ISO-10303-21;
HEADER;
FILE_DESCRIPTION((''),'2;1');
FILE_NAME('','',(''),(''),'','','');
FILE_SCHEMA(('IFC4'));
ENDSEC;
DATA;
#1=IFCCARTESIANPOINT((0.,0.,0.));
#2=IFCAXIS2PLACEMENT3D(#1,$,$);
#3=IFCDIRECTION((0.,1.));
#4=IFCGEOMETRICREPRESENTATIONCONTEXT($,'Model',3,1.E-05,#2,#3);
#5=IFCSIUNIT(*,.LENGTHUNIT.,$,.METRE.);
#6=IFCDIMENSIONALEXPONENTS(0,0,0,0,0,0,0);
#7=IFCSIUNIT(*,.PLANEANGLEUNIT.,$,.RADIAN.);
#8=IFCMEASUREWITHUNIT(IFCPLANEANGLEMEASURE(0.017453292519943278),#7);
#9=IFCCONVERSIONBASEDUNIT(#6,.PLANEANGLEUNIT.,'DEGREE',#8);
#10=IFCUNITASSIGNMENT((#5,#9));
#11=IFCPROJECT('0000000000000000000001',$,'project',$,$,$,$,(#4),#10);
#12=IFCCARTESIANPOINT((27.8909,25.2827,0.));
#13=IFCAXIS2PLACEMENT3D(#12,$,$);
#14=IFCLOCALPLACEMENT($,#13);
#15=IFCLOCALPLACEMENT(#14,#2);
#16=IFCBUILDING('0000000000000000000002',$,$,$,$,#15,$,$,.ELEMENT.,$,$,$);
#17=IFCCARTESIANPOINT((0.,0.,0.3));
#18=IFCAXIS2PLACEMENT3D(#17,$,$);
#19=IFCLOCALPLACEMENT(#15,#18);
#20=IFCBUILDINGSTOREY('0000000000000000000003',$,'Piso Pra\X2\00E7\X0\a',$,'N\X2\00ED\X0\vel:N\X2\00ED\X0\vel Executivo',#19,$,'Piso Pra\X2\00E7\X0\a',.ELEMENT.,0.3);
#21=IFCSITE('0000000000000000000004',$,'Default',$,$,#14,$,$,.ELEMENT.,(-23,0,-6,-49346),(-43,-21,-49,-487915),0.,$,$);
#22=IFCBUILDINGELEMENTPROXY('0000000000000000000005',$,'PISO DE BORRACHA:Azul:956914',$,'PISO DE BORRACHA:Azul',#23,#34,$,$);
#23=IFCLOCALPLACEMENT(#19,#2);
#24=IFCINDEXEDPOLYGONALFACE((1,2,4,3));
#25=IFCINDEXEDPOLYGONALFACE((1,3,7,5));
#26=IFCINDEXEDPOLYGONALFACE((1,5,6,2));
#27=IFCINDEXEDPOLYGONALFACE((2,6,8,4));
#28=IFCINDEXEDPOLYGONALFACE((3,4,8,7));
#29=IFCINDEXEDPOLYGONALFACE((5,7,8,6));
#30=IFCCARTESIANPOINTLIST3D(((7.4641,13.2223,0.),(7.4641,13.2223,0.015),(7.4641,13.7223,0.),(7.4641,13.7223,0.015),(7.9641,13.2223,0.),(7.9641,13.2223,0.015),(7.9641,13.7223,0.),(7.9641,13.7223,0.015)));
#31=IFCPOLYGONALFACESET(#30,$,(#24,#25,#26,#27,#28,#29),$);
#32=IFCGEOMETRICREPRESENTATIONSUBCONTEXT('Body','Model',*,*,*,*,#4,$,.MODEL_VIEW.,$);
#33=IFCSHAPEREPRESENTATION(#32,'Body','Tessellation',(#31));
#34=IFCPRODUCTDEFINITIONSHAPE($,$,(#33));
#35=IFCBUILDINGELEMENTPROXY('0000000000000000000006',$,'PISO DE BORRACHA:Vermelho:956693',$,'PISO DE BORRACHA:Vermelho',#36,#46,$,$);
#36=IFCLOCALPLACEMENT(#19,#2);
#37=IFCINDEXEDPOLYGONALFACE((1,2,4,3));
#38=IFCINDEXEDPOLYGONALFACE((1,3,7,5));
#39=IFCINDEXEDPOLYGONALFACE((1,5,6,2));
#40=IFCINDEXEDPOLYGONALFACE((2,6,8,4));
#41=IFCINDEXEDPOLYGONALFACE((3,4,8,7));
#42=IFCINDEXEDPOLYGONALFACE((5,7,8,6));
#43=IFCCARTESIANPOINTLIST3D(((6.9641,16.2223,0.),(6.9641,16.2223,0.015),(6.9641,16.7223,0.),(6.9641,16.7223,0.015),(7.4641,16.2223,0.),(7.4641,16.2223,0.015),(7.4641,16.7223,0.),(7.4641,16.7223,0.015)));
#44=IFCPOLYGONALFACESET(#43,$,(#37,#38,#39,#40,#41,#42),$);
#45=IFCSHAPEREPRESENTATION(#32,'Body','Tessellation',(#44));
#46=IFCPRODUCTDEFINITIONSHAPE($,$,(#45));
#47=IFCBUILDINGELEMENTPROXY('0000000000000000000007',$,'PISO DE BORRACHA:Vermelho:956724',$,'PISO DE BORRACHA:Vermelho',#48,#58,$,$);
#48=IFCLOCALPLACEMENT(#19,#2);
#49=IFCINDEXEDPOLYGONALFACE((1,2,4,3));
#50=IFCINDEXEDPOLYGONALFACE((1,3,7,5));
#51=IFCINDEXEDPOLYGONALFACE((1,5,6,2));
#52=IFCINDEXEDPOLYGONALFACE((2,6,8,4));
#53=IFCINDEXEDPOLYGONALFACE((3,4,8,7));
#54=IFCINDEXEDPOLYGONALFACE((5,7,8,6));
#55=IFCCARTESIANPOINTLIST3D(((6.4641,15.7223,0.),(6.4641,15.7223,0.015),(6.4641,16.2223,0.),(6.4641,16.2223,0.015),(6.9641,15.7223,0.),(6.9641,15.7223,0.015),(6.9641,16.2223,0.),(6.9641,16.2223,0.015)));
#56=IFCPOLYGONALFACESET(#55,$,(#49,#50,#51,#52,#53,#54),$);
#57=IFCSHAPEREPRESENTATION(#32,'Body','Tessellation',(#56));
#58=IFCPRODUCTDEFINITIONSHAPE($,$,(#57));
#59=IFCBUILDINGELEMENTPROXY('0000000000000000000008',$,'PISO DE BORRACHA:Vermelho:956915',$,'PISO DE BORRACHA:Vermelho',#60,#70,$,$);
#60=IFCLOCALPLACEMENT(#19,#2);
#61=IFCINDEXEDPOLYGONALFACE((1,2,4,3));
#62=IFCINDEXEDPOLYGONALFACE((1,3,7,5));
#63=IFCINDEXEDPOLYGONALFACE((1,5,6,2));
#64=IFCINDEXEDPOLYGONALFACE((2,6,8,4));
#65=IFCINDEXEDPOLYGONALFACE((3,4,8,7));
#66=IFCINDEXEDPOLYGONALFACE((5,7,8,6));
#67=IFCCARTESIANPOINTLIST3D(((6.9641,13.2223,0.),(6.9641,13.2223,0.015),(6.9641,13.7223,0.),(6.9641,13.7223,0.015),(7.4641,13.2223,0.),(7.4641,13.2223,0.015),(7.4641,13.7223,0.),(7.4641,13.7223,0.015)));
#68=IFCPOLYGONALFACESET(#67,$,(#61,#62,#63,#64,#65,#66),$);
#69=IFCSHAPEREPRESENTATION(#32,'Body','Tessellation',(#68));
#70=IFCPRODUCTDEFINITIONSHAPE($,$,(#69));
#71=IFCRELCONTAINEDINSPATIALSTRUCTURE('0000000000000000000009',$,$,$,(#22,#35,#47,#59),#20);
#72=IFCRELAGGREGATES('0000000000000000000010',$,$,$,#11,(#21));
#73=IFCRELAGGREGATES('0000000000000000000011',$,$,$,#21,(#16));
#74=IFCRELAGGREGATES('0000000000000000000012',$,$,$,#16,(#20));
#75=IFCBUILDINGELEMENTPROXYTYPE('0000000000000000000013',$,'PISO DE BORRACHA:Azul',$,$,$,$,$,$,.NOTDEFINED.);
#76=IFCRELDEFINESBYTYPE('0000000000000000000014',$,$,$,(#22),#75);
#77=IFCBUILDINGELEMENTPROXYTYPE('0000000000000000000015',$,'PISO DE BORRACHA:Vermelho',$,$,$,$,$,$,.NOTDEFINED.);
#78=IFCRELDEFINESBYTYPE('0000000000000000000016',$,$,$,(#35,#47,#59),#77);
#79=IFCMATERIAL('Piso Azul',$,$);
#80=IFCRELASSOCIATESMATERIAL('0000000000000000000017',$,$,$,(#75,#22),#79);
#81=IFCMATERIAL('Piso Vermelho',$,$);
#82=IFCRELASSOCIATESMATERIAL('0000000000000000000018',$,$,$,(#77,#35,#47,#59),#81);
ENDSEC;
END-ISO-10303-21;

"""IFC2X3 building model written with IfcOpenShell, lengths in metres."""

from ifc_helpers import new_model, entity, si_unit, converted_unit, direction, frame, origin, origin_2d_with_axis, place, context, subcontext, project, spatial, rectangle, extrude, source, transform, mapped, material, type_object, type_shapes, element, save


model = new_model("IFC2X3")

# Units and contexts
model_context = context("Model", 3, precision=1e-05, world=origin(), true_north=direction((0.0, 1.0)))
body_context = subcontext(model_context, "Body", "Model", "MODEL_VIEW")
ifc_project = project(units=[si_unit("LENGTHUNIT", "METRE"), converted_unit("PLANEANGLEUNIT", "DEGREE", entity("IfcPlaneAngleMeasure", 0.017453292519943278), si_unit("PLANEANGLEUNIT", "RADIAN"), dimensions=[0, 0, 0, 0, 0, 0, 0])], contexts=[model_context])

# Site, building, storey
site_placement = place(None, frame((27.8909, 25.2827, 0.0)))
site = spatial("IfcSite", under=ifc_project, at=site_placement, Name="Default", CompositionType="ELEMENT", RefLatitude=(-23, 0, -6, -49346), RefLongitude=(-43, -21, -49, -487915), RefElevation=0.0)
building_placement = place(site_placement, origin())
building = spatial("IfcBuilding", under=site, at=building_placement, CompositionType="ELEMENT")
storey_placement = place(building_placement, frame((0.0, 0.0, 0.3)))
storey = spatial("IfcBuildingStorey", under=building, at=storey_placement, Name="Piso Praça", ObjectType="Nível:Nível Executivo", LongName="Piso Praça", CompositionType="ELEMENT", Elevation=0.3)

# Building element proxies
ifc_material_1 = material(Name="Piso Azul")
building_element_proxy_type_1 = type_object("IfcBuildingElementProxyType", Name="PISO DE BORRACHA:Azul", PredefinedType="NOTDEFINED", material=ifc_material_1)
shared_shape_1 = source(origin(), body_context, "Body", "SweptSolid", [
    extrude(rectangle(XDim=0.5, YDim=0.5, at=origin_2d_with_axis()), frame((0.25, 0.25, 0.0), z_axis=(0.0, 0.0, 1.0), x_axis=(-1.0, 0.0, 0.0)), (0.0, 0.0, 1.0), 0.015),
])
type_shapes(building_element_proxy_type_1, [shared_shape_1])
for number, where, name in (
    (1, (7.4641, 13.2223, 0.0), "PISO DE BORRACHA:Azul:956914"),
):
    element("IfcBuildingElementProxy", number, at=place(storey_placement, frame(where)), inside=storey, type_object=building_element_proxy_type_1, material=ifc_material_1, Name=name, ObjectType="PISO DE BORRACHA:Azul", context=body_context, shape_type="MappedRepresentation", body=[
        mapped(shared_shape_1, transform((0.0, 0.0, 0.0), scale=1.0)),
    ])
ifc_material_2 = material(Name="Piso Vermelho")
building_element_proxy_type_2 = type_object("IfcBuildingElementProxyType", Name="PISO DE BORRACHA:Vermelho", PredefinedType="NOTDEFINED", material=ifc_material_2)
shared_shape_2 = source(origin(), body_context, "Body", "SweptSolid", [
    extrude(rectangle(XDim=0.5, YDim=0.5, at=origin_2d_with_axis()), frame((0.25, 0.25, 0.0), z_axis=(0.0, 0.0, 1.0), x_axis=(-1.0, 0.0, 0.0)), (0.0, 0.0, 1.0), 0.015),
])
type_shapes(building_element_proxy_type_2, [shared_shape_2])
for number, where, name in (
    (2, (6.9641, 16.2223, 0.0), "PISO DE BORRACHA:Vermelho:956693"),
    (3, (6.4641, 15.7223, 0.0), "PISO DE BORRACHA:Vermelho:956724"),
    (4, (6.9641, 13.2223, 0.0), "PISO DE BORRACHA:Vermelho:956915"),
):
    element("IfcBuildingElementProxy", number, at=place(storey_placement, frame(where)), inside=storey, type_object=building_element_proxy_type_2, material=ifc_material_2, Name=name, ObjectType="PISO DE BORRACHA:Vermelho", context=body_context, shape_type="MappedRepresentation", body=[
        mapped(shared_shape_2, transform((0.0, 0.0, 0.0), scale=1.0)),
    ])

save(model, "model.ifc")
